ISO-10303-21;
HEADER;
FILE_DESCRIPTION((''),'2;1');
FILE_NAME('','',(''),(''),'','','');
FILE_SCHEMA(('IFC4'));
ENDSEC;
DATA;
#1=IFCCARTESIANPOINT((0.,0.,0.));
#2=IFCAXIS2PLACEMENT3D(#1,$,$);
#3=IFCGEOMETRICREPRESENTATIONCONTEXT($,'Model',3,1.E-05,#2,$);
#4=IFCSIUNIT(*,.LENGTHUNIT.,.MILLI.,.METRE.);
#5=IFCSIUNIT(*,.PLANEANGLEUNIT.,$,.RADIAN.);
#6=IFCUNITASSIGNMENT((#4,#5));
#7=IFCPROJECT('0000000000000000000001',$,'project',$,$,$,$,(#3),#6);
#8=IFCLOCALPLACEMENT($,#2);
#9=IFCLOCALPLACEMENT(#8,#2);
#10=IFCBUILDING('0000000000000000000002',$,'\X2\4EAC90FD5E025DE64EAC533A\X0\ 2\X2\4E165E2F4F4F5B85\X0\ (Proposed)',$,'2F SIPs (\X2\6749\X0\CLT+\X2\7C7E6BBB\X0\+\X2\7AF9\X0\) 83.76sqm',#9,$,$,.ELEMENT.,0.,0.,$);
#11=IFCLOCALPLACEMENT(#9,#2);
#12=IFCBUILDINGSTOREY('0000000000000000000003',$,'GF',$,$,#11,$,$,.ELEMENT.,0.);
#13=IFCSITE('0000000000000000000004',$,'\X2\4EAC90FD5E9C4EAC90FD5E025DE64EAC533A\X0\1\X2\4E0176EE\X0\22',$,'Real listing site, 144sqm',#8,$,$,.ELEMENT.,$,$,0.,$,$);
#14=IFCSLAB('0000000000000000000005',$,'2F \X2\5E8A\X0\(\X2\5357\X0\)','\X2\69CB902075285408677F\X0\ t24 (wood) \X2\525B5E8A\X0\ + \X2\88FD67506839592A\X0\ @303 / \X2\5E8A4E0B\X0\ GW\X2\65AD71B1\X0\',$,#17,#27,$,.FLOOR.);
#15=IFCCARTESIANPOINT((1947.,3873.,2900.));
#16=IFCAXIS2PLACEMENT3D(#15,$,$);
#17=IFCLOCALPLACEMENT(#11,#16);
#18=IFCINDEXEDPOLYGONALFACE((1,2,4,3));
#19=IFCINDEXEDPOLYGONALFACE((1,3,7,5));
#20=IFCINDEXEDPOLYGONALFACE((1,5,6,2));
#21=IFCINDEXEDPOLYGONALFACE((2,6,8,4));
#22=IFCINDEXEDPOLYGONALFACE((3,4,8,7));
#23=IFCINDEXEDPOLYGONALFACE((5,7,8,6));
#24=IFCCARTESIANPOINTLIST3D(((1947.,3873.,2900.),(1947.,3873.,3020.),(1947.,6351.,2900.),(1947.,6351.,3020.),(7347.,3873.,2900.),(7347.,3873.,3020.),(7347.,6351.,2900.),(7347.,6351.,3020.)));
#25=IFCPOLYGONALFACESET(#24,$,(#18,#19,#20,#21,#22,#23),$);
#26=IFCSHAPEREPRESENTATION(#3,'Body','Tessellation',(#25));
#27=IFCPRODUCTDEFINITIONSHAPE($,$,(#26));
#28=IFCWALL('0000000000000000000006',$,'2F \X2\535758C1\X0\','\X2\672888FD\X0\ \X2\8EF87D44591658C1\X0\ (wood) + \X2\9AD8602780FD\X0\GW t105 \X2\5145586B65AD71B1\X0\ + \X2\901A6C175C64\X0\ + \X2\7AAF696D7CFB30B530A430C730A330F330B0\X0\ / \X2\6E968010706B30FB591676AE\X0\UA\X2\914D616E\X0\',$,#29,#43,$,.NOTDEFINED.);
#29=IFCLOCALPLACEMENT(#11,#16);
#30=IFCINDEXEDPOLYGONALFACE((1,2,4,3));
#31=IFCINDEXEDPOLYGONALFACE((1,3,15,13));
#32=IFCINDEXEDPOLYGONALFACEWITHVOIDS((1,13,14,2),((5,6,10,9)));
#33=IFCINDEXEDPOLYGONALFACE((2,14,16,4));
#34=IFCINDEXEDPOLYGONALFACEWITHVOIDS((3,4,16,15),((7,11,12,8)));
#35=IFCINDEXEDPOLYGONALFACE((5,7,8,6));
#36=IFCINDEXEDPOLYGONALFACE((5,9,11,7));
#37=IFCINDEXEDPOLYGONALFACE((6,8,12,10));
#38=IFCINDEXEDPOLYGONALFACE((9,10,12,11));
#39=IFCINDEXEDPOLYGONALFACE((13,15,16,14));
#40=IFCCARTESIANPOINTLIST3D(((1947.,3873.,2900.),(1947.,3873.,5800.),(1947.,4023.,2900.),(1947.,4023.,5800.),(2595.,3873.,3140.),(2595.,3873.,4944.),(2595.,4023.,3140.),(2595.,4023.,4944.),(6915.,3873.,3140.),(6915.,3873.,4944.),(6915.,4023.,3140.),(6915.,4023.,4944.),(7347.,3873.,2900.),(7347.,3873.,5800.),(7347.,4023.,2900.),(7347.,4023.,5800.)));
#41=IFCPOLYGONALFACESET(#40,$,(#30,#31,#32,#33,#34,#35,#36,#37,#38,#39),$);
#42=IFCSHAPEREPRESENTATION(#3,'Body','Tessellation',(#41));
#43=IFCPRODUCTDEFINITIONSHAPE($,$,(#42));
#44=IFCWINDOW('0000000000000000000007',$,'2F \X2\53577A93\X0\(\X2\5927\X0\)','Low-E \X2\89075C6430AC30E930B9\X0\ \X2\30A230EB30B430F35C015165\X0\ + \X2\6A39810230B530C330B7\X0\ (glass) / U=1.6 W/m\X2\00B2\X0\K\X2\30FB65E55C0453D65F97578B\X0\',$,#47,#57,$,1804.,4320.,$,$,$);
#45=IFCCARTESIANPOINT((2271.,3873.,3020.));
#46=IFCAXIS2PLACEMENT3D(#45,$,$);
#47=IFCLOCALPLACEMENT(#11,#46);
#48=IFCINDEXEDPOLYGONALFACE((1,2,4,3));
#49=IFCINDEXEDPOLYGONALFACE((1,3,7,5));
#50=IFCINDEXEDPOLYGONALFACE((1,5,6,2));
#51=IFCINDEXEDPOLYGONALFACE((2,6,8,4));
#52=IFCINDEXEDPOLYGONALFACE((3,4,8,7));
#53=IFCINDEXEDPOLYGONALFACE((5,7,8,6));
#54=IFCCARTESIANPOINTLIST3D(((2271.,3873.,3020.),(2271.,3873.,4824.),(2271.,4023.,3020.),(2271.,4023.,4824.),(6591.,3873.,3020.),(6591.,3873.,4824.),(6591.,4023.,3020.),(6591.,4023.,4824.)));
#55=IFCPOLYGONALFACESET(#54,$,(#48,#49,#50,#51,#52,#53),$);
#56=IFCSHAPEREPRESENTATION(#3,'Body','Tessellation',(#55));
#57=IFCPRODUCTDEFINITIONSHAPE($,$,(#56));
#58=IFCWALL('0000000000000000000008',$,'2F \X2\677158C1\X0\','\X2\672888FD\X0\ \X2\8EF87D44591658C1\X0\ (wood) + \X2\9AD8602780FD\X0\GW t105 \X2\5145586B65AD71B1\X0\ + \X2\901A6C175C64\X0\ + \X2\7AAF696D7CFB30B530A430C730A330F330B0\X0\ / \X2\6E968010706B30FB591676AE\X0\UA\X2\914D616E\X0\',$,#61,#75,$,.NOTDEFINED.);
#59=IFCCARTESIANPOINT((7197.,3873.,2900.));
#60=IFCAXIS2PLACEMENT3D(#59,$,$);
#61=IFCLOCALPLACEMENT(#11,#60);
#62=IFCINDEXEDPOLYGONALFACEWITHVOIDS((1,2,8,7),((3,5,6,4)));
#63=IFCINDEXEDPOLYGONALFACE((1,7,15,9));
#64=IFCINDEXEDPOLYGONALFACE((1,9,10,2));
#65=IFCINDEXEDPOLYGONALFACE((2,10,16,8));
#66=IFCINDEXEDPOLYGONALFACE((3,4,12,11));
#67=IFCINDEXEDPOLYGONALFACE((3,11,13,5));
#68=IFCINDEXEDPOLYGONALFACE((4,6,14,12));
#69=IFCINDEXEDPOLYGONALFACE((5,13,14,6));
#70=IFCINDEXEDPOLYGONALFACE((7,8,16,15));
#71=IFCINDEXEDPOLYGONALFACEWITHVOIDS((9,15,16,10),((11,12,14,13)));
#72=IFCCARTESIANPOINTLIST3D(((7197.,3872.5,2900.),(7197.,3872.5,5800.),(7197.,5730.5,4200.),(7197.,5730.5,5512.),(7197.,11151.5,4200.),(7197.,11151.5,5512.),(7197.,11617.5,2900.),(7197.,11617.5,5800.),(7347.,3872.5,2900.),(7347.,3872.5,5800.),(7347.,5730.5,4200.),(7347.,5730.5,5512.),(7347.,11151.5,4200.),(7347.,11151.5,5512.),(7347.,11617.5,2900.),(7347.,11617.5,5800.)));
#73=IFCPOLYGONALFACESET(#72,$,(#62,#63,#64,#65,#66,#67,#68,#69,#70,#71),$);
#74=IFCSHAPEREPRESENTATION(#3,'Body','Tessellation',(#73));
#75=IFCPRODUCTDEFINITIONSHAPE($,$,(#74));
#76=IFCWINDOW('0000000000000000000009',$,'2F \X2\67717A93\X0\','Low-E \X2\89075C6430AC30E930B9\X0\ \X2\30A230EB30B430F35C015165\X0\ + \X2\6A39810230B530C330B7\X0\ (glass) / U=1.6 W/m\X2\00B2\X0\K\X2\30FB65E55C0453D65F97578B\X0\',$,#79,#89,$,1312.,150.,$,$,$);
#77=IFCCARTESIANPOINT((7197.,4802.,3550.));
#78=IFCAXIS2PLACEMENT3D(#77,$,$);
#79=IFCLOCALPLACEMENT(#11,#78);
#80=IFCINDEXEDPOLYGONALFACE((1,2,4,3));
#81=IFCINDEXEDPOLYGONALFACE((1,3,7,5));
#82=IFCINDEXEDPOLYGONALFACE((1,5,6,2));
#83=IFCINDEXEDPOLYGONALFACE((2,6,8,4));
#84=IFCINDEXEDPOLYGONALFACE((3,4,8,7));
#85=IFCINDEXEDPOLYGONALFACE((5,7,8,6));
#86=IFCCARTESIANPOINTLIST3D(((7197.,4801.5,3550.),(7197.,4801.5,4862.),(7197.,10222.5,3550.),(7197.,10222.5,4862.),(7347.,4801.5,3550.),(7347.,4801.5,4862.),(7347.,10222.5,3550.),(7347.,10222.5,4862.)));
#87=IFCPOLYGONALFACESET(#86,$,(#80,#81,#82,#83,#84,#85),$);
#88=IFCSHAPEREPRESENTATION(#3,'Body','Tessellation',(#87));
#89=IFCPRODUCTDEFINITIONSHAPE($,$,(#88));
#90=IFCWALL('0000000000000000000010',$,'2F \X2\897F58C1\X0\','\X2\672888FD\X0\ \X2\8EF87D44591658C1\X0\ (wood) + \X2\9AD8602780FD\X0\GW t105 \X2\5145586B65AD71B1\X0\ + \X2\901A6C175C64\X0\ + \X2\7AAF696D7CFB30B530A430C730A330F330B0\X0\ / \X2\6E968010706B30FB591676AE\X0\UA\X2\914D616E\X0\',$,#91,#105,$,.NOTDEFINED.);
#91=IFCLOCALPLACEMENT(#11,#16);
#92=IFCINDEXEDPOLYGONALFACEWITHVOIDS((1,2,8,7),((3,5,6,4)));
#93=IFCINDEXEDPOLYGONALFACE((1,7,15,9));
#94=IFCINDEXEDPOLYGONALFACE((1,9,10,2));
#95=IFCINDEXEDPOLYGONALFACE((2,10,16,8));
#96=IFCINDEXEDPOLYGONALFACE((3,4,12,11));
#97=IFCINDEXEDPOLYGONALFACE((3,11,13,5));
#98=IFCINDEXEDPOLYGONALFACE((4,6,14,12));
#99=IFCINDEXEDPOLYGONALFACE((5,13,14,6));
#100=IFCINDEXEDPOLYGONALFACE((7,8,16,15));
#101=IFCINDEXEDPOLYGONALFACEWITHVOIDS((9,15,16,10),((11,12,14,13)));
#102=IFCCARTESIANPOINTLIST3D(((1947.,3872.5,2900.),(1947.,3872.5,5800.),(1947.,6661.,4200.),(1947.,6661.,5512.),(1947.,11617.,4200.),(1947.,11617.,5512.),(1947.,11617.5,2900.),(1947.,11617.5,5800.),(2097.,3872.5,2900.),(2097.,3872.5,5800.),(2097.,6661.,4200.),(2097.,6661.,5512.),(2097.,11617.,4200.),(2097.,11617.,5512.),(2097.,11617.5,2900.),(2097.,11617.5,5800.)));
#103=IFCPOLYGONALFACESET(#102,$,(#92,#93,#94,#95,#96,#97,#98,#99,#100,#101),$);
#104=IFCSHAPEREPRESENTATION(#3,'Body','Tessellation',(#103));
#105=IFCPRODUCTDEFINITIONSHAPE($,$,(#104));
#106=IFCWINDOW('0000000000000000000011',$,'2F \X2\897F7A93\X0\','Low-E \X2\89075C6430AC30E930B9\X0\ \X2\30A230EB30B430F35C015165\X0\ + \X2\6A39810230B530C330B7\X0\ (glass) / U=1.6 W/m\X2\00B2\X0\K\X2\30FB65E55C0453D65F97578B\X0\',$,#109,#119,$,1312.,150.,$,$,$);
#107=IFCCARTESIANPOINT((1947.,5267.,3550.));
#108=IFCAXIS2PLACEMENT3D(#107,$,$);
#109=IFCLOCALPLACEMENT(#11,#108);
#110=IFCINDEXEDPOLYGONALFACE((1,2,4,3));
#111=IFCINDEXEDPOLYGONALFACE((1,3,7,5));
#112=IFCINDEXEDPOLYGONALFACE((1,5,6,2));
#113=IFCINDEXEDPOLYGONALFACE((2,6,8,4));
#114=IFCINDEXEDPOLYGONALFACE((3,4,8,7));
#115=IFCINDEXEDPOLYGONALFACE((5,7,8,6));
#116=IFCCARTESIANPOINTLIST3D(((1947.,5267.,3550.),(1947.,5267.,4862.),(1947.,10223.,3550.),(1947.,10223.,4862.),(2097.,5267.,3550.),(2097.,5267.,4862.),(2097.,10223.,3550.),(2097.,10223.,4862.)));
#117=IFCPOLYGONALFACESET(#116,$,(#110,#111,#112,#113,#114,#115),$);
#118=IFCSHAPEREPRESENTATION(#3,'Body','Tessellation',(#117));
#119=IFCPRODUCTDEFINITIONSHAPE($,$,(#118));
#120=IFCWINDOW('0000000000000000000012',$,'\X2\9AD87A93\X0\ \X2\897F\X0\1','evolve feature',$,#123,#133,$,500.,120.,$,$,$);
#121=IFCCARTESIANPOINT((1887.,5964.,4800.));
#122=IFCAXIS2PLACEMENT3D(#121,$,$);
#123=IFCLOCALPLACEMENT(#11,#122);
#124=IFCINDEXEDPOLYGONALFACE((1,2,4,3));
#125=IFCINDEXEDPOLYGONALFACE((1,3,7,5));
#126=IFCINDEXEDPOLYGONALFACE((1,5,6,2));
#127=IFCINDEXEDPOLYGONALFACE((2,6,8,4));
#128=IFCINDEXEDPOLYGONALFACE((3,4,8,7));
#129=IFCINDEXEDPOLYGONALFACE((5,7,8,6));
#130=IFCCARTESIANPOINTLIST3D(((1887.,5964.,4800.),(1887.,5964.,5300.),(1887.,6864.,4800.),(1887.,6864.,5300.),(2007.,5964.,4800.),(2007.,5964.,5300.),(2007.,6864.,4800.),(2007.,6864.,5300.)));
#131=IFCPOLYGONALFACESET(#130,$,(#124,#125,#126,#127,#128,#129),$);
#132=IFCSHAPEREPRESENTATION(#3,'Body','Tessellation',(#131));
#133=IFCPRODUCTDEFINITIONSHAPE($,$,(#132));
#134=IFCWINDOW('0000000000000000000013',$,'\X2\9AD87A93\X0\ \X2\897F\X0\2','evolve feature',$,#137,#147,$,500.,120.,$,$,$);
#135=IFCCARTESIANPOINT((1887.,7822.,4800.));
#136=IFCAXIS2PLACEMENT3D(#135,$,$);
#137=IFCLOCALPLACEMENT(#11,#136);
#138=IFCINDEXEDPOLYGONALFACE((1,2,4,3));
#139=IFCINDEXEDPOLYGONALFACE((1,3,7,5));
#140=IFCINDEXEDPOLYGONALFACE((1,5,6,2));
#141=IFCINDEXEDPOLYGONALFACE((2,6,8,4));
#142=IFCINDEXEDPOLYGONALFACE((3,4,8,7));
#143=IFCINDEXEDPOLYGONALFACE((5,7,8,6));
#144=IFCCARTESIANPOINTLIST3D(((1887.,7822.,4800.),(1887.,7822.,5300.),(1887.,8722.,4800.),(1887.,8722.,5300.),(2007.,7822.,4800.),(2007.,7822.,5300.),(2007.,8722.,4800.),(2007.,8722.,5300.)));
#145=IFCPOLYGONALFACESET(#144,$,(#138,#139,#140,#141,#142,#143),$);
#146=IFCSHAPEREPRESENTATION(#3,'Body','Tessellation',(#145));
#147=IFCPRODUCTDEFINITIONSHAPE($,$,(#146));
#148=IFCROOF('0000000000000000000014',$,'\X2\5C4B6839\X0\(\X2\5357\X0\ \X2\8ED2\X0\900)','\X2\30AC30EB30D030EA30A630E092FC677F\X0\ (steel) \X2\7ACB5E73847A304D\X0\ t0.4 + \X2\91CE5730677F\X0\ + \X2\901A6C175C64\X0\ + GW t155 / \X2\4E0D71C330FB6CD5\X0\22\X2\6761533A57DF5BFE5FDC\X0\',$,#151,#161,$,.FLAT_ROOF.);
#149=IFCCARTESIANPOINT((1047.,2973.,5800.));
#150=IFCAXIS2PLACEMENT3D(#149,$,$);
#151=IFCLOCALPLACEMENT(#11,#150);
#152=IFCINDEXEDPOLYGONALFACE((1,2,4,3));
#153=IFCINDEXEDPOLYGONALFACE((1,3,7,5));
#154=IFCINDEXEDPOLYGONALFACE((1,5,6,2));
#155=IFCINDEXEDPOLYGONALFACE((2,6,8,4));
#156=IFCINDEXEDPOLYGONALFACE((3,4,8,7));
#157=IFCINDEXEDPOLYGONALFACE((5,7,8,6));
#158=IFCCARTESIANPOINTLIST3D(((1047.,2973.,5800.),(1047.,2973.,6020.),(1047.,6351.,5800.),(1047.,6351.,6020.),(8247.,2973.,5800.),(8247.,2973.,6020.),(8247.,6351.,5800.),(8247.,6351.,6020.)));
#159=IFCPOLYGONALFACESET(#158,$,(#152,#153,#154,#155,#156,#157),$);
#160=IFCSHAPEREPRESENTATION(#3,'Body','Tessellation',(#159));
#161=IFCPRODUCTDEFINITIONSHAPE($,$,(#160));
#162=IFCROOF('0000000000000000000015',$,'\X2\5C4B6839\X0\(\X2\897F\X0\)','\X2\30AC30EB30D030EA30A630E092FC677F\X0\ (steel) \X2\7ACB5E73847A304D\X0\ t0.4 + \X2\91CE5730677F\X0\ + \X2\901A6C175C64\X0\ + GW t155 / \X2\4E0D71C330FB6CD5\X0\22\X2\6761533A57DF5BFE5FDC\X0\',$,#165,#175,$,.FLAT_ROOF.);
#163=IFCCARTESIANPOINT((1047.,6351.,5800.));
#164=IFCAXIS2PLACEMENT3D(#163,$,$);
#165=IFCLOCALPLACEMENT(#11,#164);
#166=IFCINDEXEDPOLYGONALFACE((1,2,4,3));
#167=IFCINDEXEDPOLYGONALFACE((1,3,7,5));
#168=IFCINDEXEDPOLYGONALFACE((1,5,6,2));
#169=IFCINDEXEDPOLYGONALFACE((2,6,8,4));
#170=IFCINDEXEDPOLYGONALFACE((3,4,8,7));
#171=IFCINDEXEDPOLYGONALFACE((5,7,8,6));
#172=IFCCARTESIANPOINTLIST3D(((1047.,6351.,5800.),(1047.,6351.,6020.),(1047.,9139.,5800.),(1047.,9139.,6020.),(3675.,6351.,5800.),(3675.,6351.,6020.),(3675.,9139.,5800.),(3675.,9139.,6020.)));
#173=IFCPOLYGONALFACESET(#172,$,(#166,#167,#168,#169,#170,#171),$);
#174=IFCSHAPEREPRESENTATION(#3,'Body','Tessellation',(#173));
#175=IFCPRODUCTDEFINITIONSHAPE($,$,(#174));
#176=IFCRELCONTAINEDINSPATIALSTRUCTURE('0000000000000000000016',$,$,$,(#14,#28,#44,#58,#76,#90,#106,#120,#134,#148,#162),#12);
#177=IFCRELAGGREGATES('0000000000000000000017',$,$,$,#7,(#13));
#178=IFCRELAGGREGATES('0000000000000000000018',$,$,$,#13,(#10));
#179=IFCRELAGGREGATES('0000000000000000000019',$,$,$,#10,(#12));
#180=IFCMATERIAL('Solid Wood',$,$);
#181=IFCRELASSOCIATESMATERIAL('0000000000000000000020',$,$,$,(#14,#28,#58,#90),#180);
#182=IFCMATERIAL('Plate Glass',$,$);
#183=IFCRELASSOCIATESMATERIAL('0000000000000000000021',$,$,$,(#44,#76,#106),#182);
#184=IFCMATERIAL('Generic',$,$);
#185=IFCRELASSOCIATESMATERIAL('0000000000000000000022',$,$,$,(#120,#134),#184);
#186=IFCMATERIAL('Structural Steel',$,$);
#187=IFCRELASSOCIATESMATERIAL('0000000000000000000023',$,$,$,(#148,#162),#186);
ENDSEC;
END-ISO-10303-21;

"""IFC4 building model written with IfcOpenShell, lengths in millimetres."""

from ifc_helpers import new_model, si_unit, frame, frame_2d, origin, place, context, project, spatial, rectangle, extrude, material, element, fill, save


model = new_model("IFC4")

# Units and contexts
model_context = context("Model", 3, precision=1e-05, world=origin())
ifc_project = project(units=[si_unit("LENGTHUNIT", "METRE", prefix="MILLI"), si_unit("PLANEANGLEUNIT", "RADIAN")], contexts=[model_context])

# Site, building, storey
site_placement = place(None, origin())
site = spatial("IfcSite", under=ifc_project, at=site_placement, Name="京都府京都市左京区1丁目22", ObjectType="Real listing site, 144sqm", CompositionType="ELEMENT", RefElevation=0.0)
building_placement = place(site_placement, origin())
building = spatial("IfcBuilding", under=site, at=building_placement, Name="京都市左京区 2世帯住宅 (Proposed)", ObjectType="2F SIPs (杉CLT+籾殻+竹) 83.76sqm", CompositionType="ELEMENT", ElevationOfRefHeight=0.0, ElevationOfTerrain=0.0)
storey_placement = place(building_placement, origin())
storey = spatial("IfcBuildingStorey", under=building, at=storey_placement, Name="GF", CompositionType="ELEMENT", Elevation=0.0)

# Slab
ifc_material_1 = material(Name="Solid Wood")
slab_placement = place(storey_placement, frame((1947.0, 3873.0, 2900.0)))
element("IfcSlab", 1, at=slab_placement, inside=storey, material=ifc_material_1, Name="2F 床(南)", Description="構造用合板 t24 (wood) 剛床 + 製材根太 @303 / 床下 GW断熱", PredefinedType="FLOOR", context=model_context, shape_type="SweptSolid", body=[
    extrude(rectangle(XDim=5400.0, YDim=2478.0, at=frame_2d((2700.0, 1239.0))), frame((1947.0, 3873.0, 2900.0)), (0.0, 0.0, 1.0), 120.0),
])

# Walls, openings, windows
wall_1_placement = place(storey_placement, frame((1947.0, 3873.0, 2900.0)))
wall_1 = element("IfcWall", 2, at=wall_1_placement, inside=storey, material=ifc_material_1, Name="2F 南壁", Description="木製 軸組外壁 (wood) + 高性能GW t105 充填断熱 + 通気層 + 窯業系サイディング / 準耐火・外皮UA配慮", PredefinedType="NOTDEFINED", context=model_context, shape_type="SweptSolid", body=[
    extrude(rectangle(XDim=5400.0, YDim=150.0, at=frame_2d((2700.0, 75.0))), frame((1947.0, 3873.0, 2900.0)), (0.0, 0.0, 1.0), 2900.0),
])
opening_1_placement = place(storey_placement, frame((2271.0, 3873.0, 3020.0)))
opening_1 = element("IfcOpeningElement", 3, at=opening_1_placement, cuts=wall_1, PredefinedType="NOTDEFINED", context=model_context, shape_type="SweptSolid", body=[
    extrude(rectangle(XDim=4320.0, YDim=150.0, at=frame_2d((2160.0, 75.0))), frame((2271.0, 3873.0, 3020.0)), (0.0, 0.0, 1.0), 1804.0),
])
ifc_material_2 = material(Name="Plate Glass")
window_1_placement = place(storey_placement, frame((2271.0, 3873.0, 3020.0)))
window_1 = element("IfcWindow", 4, at=window_1_placement, inside=storey, material=ifc_material_2, Name="2F 南窓(大)", Description="Low-E 複層ガラス アルゴン封入 + 樹脂サッシ (glass) / U=1.6 W/m²K・日射取得型", OverallHeight=1804.0, OverallWidth=4320.0, context=model_context, shape_type="SweptSolid", body=[
    extrude(rectangle(XDim=4320.0, YDim=150.0, at=frame_2d((2160.0, 75.0))), frame((2271.0, 3873.0, 3020.0)), (0.0, 0.0, 1.0), 1804.0),
])
fill(opening_1, window_1)
wall_2_placement = place(storey_placement, frame((7197.0, 3873.0, 2900.0)))
wall_2 = element("IfcWall", 5, at=wall_2_placement, inside=storey, material=ifc_material_1, Name="2F 東壁", Description="木製 軸組外壁 (wood) + 高性能GW t105 充填断熱 + 通気層 + 窯業系サイディング / 準耐火・外皮UA配慮", PredefinedType="NOTDEFINED", context=model_context, shape_type="SweptSolid", body=[
    extrude(rectangle(XDim=150.0, YDim=7745.0, at=frame_2d((75.0, 3872.0))), frame((7197.0, 3873.0, 2900.0)), (0.0, 0.0, 1.0), 2900.0),
])
opening_2_placement = place(storey_placement, frame((7197.0, 4802.0, 3550.0)))
opening_2 = element("IfcOpeningElement", 6, at=opening_2_placement, cuts=wall_2, PredefinedType="NOTDEFINED", context=model_context, shape_type="SweptSolid", body=[
    extrude(rectangle(XDim=150.0, YDim=5421.0, at=frame_2d((75.0, 2710.0))), frame((7197.0, 4802.0, 3550.0)), (0.0, 0.0, 1.0), 1312.0),
])
window_2_placement = place(storey_placement, frame((7197.0, 4802.0, 3550.0)))
window_2 = element("IfcWindow", 7, at=window_2_placement, inside=storey, material=ifc_material_2, Name="2F 東窓", Description="Low-E 複層ガラス アルゴン封入 + 樹脂サッシ (glass) / U=1.6 W/m²K・日射取得型", OverallHeight=1312.0, OverallWidth=150.0, context=model_context, shape_type="SweptSolid", body=[
    extrude(rectangle(XDim=150.0, YDim=5421.0, at=frame_2d((75.0, 2710.0))), frame((7197.0, 4802.0, 3550.0)), (0.0, 0.0, 1.0), 1312.0),
])
fill(opening_2, window_2)

# Wall, openings, windows
wall_3_placement = place(storey_placement, frame((1947.0, 3873.0, 2900.0)))
wall_3 = element("IfcWall", 8, at=wall_3_placement, inside=storey, material=ifc_material_1, Name="2F 西壁", Description="木製 軸組外壁 (wood) + 高性能GW t105 充填断熱 + 通気層 + 窯業系サイディング / 準耐火・外皮UA配慮", PredefinedType="NOTDEFINED", context=model_context, shape_type="SweptSolid", body=[
    extrude(rectangle(XDim=150.0, YDim=7745.0, at=frame_2d((75.0, 3872.0))), frame((1947.0, 3873.0, 2900.0)), (0.0, 0.0, 1.0), 2900.0),
])
opening_3_placement = place(storey_placement, frame((1947.0, 5267.0, 3550.0)))
opening_3 = element("IfcOpeningElement", 9, at=opening_3_placement, cuts=wall_3, PredefinedType="NOTDEFINED", context=model_context, shape_type="SweptSolid", body=[
    extrude(rectangle(XDim=150.0, YDim=4956.0, at=frame_2d((75.0, 2478.0))), frame((1947.0, 5267.0, 3550.0)), (0.0, 0.0, 1.0), 1312.0),
])
opening_4_placement = place(storey_placement, frame((1887.0, 5964.0, 4800.0)))
opening_4 = element("IfcOpeningElement", 10, at=opening_4_placement, cuts=wall_3, PredefinedType="NOTDEFINED", context=model_context, shape_type="SweptSolid", body=[
    extrude(rectangle(XDim=120.0, YDim=900.0, at=frame_2d((60.0, 450.0))), frame((1887.0, 5964.0, 4800.0)), (0.0, 0.0, 1.0), 500.0),
])
opening_5_placement = place(storey_placement, frame((1887.0, 7822.0, 4800.0)))
opening_5 = element("IfcOpeningElement", 11, at=opening_5_placement, cuts=wall_3, PredefinedType="NOTDEFINED", context=model_context, shape_type="SweptSolid", body=[
    extrude(rectangle(XDim=120.0, YDim=900.0, at=frame_2d((60.0, 450.0))), frame((1887.0, 7822.0, 4800.0)), (0.0, 0.0, 1.0), 500.0),
])
window_3_placement = place(storey_placement, frame((1947.0, 5267.0, 3550.0)))
window_3 = element("IfcWindow", 12, at=window_3_placement, inside=storey, material=ifc_material_2, Name="2F 西窓", Description="Low-E 複層ガラス アルゴン封入 + 樹脂サッシ (glass) / U=1.6 W/m²K・日射取得型", OverallHeight=1312.0, OverallWidth=150.0, context=model_context, shape_type="SweptSolid", body=[
    extrude(rectangle(XDim=150.0, YDim=4956.0, at=frame_2d((75.0, 2478.0))), frame((1947.0, 5267.0, 3550.0)), (0.0, 0.0, 1.0), 1312.0),
])
fill(opening_3, window_3)
ifc_material_3 = material(Name="Generic")
window_4_placement = place(storey_placement, frame((1887.0, 5964.0, 4800.0)))
window_4 = element("IfcWindow", 13, at=window_4_placement, inside=storey, material=ifc_material_3, Name="高窓 西1", Description="evolve feature", OverallHeight=500.0, OverallWidth=120.0, context=model_context, shape_type="SweptSolid", body=[
    extrude(rectangle(XDim=120.0, YDim=900.0, at=frame_2d((60.0, 450.0))), frame((1887.0, 5964.0, 4800.0)), (0.0, 0.0, 1.0), 500.0),
])
fill(opening_4, window_4)
window_5_placement = place(storey_placement, frame((1887.0, 7822.0, 4800.0)))
window_5 = element("IfcWindow", 14, at=window_5_placement, inside=storey, material=ifc_material_3, Name="高窓 西2", Description="evolve feature", OverallHeight=500.0, OverallWidth=120.0, context=model_context, shape_type="SweptSolid", body=[
    extrude(rectangle(XDim=120.0, YDim=900.0, at=frame_2d((60.0, 450.0))), frame((1887.0, 7822.0, 4800.0)), (0.0, 0.0, 1.0), 500.0),
])
fill(opening_5, window_5)

# Roofs
ifc_material_4 = material(Name="Structural Steel")
roof_1_placement = place(storey_placement, frame((1047.0, 2973.0, 5800.0)))
element("IfcRoof", 15, at=roof_1_placement, inside=storey, material=ifc_material_4, Name="屋根(南 軒900)", Description="ガルバリウム鋼板 (steel) 立平葺き t0.4 + 野地板 + 通気層 + GW t155 / 不燃・法22条区域対応", PredefinedType="FLAT_ROOF", context=model_context, shape_type="SweptSolid", body=[
    extrude(rectangle(XDim=7200.0, YDim=3378.0, at=frame_2d((3600.0, 1689.0))), frame((1047.0, 2973.0, 5800.0)), (0.0, 0.0, 1.0), 220.0),
])
roof_2_placement = place(storey_placement, frame((1047.0, 6351.0, 5800.0)))
element("IfcRoof", 16, at=roof_2_placement, inside=storey, material=ifc_material_4, Name="屋根(西)", Description="ガルバリウム鋼板 (steel) 立平葺き t0.4 + 野地板 + 通気層 + GW t155 / 不燃・法22条区域対応", PredefinedType="FLAT_ROOF", context=model_context, shape_type="SweptSolid", body=[
    extrude(rectangle(XDim=2628.0, YDim=2788.0, at=frame_2d((1314.0, 1394.0))), frame((1047.0, 6351.0, 5800.0)), (0.0, 0.0, 1.0), 220.0),
])

save(model, "model.ifc")
